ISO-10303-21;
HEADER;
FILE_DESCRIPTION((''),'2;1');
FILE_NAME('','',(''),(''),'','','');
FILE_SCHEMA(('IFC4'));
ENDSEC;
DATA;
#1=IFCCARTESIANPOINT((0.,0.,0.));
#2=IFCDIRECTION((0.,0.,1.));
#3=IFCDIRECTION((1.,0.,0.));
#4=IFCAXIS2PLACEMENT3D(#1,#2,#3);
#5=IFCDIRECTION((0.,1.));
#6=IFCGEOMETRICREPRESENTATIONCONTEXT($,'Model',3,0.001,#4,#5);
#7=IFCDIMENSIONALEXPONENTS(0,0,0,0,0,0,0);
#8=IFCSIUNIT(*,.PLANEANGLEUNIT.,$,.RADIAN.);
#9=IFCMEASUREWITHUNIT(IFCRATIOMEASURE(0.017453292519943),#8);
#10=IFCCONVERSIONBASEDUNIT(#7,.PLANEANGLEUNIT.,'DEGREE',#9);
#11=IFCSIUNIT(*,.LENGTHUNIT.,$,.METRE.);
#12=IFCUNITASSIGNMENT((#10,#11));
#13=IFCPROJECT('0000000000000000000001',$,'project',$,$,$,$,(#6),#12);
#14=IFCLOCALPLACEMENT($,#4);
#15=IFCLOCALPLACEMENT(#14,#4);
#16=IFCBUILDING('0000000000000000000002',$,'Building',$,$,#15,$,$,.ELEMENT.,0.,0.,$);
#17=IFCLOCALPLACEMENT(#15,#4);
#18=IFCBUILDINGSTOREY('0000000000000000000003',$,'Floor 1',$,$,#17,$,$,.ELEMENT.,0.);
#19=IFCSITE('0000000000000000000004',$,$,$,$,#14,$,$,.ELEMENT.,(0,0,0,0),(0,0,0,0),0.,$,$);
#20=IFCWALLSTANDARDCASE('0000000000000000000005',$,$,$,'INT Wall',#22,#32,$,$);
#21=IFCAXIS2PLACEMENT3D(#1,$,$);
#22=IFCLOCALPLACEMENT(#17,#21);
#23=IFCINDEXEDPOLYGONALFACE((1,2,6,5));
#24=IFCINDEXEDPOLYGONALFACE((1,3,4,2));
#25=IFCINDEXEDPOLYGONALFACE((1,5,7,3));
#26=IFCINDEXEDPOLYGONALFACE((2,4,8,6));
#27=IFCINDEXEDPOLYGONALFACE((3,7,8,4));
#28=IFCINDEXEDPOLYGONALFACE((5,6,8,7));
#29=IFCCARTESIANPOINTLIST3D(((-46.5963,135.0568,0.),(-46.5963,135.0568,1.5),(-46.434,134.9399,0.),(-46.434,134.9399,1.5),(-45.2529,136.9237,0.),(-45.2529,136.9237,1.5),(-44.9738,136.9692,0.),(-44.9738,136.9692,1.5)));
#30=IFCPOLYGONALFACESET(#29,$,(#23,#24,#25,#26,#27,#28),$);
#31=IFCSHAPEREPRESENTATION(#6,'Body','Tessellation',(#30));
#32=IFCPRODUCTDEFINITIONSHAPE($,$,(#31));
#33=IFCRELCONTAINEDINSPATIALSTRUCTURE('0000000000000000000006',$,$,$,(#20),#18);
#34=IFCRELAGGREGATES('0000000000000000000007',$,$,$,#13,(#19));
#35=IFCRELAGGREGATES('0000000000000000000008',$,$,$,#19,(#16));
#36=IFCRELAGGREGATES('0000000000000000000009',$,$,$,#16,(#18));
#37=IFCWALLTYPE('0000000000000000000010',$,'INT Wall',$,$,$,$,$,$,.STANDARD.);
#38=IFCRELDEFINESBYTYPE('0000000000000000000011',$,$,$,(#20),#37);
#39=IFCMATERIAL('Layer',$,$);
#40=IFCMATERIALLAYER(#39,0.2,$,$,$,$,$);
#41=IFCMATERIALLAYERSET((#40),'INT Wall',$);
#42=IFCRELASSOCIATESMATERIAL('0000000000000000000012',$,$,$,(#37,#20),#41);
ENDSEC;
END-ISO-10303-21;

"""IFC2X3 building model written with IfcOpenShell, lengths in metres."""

from ifc_helpers import new_model, entity, si_unit, converted_unit, direction, frame, origin_with_axes, place, context, project, spatial, polyline, outline, extrude, material, layer, layer_set, layer_usage, type_object, element, save


model = new_model("IFC2X3")

# Units and contexts
model_context = context("Model", 3, precision=0.001, world=origin_with_axes(), true_north=direction((0.0, 1.0)))
ifc_project = project(units=[converted_unit("PLANEANGLEUNIT", "DEGREE", entity("IfcRatioMeasure", 0.017453292519943), si_unit("PLANEANGLEUNIT", "RADIAN"), dimensions=[0, 0, 0, 0, 0, 0, 0]), si_unit("LENGTHUNIT", "METRE")], contexts=[model_context])

# Site, building, storey
site_placement = place(None, origin_with_axes())
site = spatial("IfcSite", under=ifc_project, at=site_placement, CompositionType="ELEMENT", RefLatitude=(0, 0, 0, 0), RefLongitude=(0, 0, 0, 0), RefElevation=0.0)
building_placement = place(site_placement, origin_with_axes())
building = spatial("IfcBuilding", under=site, at=building_placement, Name="Building", CompositionType="ELEMENT", ElevationOfRefHeight=0.0, ElevationOfTerrain=0.0)
storey_placement = place(building_placement, origin_with_axes())
storey = spatial("IfcBuildingStorey", under=building, at=storey_placement, Name="Floor 1", CompositionType="ELEMENT", Elevation=0.0)

# Wall
ifc_material_1 = material(Name="Layer")
ifc_layer_1 = layer(ifc_material_1, 0.2)
ifc_layer_set_1 = layer_set([ifc_layer_1], Name="INT Wall")
ifc_layer_usage_1 = layer_usage(ifc_layer_set_1, "AXIS2", "POSITIVE", -0.1)
wall_type_1 = type_object("IfcWallType", Name="INT Wall", PredefinedType="STANDARD", material=ifc_layer_set_1)
wall_1_placement = place(site_placement, frame((-46.5735, 134.9172, 0.0), z_axis=(0.0, 0.0, 1.0), x_axis=(0.584065, 0.811707, 0.0)))
element("IfcWallStandardCase", 1, at=wall_1_placement, inside=storey, type_object=wall_type_1, material=ifc_layer_usage_1, ObjectType="INT Wall", context=model_context, shape_type="SweptSolid", body=[
    extrude(outline(polyline([(0.1, -0.1), (0.1, 0.1), (2.4, 0.1), (2.6, -0.1), (0.1, -0.1)])), origin_with_axes(), (0.0, 0.0, 1.0), 1.5),
])

save(model, "model.ifc")
